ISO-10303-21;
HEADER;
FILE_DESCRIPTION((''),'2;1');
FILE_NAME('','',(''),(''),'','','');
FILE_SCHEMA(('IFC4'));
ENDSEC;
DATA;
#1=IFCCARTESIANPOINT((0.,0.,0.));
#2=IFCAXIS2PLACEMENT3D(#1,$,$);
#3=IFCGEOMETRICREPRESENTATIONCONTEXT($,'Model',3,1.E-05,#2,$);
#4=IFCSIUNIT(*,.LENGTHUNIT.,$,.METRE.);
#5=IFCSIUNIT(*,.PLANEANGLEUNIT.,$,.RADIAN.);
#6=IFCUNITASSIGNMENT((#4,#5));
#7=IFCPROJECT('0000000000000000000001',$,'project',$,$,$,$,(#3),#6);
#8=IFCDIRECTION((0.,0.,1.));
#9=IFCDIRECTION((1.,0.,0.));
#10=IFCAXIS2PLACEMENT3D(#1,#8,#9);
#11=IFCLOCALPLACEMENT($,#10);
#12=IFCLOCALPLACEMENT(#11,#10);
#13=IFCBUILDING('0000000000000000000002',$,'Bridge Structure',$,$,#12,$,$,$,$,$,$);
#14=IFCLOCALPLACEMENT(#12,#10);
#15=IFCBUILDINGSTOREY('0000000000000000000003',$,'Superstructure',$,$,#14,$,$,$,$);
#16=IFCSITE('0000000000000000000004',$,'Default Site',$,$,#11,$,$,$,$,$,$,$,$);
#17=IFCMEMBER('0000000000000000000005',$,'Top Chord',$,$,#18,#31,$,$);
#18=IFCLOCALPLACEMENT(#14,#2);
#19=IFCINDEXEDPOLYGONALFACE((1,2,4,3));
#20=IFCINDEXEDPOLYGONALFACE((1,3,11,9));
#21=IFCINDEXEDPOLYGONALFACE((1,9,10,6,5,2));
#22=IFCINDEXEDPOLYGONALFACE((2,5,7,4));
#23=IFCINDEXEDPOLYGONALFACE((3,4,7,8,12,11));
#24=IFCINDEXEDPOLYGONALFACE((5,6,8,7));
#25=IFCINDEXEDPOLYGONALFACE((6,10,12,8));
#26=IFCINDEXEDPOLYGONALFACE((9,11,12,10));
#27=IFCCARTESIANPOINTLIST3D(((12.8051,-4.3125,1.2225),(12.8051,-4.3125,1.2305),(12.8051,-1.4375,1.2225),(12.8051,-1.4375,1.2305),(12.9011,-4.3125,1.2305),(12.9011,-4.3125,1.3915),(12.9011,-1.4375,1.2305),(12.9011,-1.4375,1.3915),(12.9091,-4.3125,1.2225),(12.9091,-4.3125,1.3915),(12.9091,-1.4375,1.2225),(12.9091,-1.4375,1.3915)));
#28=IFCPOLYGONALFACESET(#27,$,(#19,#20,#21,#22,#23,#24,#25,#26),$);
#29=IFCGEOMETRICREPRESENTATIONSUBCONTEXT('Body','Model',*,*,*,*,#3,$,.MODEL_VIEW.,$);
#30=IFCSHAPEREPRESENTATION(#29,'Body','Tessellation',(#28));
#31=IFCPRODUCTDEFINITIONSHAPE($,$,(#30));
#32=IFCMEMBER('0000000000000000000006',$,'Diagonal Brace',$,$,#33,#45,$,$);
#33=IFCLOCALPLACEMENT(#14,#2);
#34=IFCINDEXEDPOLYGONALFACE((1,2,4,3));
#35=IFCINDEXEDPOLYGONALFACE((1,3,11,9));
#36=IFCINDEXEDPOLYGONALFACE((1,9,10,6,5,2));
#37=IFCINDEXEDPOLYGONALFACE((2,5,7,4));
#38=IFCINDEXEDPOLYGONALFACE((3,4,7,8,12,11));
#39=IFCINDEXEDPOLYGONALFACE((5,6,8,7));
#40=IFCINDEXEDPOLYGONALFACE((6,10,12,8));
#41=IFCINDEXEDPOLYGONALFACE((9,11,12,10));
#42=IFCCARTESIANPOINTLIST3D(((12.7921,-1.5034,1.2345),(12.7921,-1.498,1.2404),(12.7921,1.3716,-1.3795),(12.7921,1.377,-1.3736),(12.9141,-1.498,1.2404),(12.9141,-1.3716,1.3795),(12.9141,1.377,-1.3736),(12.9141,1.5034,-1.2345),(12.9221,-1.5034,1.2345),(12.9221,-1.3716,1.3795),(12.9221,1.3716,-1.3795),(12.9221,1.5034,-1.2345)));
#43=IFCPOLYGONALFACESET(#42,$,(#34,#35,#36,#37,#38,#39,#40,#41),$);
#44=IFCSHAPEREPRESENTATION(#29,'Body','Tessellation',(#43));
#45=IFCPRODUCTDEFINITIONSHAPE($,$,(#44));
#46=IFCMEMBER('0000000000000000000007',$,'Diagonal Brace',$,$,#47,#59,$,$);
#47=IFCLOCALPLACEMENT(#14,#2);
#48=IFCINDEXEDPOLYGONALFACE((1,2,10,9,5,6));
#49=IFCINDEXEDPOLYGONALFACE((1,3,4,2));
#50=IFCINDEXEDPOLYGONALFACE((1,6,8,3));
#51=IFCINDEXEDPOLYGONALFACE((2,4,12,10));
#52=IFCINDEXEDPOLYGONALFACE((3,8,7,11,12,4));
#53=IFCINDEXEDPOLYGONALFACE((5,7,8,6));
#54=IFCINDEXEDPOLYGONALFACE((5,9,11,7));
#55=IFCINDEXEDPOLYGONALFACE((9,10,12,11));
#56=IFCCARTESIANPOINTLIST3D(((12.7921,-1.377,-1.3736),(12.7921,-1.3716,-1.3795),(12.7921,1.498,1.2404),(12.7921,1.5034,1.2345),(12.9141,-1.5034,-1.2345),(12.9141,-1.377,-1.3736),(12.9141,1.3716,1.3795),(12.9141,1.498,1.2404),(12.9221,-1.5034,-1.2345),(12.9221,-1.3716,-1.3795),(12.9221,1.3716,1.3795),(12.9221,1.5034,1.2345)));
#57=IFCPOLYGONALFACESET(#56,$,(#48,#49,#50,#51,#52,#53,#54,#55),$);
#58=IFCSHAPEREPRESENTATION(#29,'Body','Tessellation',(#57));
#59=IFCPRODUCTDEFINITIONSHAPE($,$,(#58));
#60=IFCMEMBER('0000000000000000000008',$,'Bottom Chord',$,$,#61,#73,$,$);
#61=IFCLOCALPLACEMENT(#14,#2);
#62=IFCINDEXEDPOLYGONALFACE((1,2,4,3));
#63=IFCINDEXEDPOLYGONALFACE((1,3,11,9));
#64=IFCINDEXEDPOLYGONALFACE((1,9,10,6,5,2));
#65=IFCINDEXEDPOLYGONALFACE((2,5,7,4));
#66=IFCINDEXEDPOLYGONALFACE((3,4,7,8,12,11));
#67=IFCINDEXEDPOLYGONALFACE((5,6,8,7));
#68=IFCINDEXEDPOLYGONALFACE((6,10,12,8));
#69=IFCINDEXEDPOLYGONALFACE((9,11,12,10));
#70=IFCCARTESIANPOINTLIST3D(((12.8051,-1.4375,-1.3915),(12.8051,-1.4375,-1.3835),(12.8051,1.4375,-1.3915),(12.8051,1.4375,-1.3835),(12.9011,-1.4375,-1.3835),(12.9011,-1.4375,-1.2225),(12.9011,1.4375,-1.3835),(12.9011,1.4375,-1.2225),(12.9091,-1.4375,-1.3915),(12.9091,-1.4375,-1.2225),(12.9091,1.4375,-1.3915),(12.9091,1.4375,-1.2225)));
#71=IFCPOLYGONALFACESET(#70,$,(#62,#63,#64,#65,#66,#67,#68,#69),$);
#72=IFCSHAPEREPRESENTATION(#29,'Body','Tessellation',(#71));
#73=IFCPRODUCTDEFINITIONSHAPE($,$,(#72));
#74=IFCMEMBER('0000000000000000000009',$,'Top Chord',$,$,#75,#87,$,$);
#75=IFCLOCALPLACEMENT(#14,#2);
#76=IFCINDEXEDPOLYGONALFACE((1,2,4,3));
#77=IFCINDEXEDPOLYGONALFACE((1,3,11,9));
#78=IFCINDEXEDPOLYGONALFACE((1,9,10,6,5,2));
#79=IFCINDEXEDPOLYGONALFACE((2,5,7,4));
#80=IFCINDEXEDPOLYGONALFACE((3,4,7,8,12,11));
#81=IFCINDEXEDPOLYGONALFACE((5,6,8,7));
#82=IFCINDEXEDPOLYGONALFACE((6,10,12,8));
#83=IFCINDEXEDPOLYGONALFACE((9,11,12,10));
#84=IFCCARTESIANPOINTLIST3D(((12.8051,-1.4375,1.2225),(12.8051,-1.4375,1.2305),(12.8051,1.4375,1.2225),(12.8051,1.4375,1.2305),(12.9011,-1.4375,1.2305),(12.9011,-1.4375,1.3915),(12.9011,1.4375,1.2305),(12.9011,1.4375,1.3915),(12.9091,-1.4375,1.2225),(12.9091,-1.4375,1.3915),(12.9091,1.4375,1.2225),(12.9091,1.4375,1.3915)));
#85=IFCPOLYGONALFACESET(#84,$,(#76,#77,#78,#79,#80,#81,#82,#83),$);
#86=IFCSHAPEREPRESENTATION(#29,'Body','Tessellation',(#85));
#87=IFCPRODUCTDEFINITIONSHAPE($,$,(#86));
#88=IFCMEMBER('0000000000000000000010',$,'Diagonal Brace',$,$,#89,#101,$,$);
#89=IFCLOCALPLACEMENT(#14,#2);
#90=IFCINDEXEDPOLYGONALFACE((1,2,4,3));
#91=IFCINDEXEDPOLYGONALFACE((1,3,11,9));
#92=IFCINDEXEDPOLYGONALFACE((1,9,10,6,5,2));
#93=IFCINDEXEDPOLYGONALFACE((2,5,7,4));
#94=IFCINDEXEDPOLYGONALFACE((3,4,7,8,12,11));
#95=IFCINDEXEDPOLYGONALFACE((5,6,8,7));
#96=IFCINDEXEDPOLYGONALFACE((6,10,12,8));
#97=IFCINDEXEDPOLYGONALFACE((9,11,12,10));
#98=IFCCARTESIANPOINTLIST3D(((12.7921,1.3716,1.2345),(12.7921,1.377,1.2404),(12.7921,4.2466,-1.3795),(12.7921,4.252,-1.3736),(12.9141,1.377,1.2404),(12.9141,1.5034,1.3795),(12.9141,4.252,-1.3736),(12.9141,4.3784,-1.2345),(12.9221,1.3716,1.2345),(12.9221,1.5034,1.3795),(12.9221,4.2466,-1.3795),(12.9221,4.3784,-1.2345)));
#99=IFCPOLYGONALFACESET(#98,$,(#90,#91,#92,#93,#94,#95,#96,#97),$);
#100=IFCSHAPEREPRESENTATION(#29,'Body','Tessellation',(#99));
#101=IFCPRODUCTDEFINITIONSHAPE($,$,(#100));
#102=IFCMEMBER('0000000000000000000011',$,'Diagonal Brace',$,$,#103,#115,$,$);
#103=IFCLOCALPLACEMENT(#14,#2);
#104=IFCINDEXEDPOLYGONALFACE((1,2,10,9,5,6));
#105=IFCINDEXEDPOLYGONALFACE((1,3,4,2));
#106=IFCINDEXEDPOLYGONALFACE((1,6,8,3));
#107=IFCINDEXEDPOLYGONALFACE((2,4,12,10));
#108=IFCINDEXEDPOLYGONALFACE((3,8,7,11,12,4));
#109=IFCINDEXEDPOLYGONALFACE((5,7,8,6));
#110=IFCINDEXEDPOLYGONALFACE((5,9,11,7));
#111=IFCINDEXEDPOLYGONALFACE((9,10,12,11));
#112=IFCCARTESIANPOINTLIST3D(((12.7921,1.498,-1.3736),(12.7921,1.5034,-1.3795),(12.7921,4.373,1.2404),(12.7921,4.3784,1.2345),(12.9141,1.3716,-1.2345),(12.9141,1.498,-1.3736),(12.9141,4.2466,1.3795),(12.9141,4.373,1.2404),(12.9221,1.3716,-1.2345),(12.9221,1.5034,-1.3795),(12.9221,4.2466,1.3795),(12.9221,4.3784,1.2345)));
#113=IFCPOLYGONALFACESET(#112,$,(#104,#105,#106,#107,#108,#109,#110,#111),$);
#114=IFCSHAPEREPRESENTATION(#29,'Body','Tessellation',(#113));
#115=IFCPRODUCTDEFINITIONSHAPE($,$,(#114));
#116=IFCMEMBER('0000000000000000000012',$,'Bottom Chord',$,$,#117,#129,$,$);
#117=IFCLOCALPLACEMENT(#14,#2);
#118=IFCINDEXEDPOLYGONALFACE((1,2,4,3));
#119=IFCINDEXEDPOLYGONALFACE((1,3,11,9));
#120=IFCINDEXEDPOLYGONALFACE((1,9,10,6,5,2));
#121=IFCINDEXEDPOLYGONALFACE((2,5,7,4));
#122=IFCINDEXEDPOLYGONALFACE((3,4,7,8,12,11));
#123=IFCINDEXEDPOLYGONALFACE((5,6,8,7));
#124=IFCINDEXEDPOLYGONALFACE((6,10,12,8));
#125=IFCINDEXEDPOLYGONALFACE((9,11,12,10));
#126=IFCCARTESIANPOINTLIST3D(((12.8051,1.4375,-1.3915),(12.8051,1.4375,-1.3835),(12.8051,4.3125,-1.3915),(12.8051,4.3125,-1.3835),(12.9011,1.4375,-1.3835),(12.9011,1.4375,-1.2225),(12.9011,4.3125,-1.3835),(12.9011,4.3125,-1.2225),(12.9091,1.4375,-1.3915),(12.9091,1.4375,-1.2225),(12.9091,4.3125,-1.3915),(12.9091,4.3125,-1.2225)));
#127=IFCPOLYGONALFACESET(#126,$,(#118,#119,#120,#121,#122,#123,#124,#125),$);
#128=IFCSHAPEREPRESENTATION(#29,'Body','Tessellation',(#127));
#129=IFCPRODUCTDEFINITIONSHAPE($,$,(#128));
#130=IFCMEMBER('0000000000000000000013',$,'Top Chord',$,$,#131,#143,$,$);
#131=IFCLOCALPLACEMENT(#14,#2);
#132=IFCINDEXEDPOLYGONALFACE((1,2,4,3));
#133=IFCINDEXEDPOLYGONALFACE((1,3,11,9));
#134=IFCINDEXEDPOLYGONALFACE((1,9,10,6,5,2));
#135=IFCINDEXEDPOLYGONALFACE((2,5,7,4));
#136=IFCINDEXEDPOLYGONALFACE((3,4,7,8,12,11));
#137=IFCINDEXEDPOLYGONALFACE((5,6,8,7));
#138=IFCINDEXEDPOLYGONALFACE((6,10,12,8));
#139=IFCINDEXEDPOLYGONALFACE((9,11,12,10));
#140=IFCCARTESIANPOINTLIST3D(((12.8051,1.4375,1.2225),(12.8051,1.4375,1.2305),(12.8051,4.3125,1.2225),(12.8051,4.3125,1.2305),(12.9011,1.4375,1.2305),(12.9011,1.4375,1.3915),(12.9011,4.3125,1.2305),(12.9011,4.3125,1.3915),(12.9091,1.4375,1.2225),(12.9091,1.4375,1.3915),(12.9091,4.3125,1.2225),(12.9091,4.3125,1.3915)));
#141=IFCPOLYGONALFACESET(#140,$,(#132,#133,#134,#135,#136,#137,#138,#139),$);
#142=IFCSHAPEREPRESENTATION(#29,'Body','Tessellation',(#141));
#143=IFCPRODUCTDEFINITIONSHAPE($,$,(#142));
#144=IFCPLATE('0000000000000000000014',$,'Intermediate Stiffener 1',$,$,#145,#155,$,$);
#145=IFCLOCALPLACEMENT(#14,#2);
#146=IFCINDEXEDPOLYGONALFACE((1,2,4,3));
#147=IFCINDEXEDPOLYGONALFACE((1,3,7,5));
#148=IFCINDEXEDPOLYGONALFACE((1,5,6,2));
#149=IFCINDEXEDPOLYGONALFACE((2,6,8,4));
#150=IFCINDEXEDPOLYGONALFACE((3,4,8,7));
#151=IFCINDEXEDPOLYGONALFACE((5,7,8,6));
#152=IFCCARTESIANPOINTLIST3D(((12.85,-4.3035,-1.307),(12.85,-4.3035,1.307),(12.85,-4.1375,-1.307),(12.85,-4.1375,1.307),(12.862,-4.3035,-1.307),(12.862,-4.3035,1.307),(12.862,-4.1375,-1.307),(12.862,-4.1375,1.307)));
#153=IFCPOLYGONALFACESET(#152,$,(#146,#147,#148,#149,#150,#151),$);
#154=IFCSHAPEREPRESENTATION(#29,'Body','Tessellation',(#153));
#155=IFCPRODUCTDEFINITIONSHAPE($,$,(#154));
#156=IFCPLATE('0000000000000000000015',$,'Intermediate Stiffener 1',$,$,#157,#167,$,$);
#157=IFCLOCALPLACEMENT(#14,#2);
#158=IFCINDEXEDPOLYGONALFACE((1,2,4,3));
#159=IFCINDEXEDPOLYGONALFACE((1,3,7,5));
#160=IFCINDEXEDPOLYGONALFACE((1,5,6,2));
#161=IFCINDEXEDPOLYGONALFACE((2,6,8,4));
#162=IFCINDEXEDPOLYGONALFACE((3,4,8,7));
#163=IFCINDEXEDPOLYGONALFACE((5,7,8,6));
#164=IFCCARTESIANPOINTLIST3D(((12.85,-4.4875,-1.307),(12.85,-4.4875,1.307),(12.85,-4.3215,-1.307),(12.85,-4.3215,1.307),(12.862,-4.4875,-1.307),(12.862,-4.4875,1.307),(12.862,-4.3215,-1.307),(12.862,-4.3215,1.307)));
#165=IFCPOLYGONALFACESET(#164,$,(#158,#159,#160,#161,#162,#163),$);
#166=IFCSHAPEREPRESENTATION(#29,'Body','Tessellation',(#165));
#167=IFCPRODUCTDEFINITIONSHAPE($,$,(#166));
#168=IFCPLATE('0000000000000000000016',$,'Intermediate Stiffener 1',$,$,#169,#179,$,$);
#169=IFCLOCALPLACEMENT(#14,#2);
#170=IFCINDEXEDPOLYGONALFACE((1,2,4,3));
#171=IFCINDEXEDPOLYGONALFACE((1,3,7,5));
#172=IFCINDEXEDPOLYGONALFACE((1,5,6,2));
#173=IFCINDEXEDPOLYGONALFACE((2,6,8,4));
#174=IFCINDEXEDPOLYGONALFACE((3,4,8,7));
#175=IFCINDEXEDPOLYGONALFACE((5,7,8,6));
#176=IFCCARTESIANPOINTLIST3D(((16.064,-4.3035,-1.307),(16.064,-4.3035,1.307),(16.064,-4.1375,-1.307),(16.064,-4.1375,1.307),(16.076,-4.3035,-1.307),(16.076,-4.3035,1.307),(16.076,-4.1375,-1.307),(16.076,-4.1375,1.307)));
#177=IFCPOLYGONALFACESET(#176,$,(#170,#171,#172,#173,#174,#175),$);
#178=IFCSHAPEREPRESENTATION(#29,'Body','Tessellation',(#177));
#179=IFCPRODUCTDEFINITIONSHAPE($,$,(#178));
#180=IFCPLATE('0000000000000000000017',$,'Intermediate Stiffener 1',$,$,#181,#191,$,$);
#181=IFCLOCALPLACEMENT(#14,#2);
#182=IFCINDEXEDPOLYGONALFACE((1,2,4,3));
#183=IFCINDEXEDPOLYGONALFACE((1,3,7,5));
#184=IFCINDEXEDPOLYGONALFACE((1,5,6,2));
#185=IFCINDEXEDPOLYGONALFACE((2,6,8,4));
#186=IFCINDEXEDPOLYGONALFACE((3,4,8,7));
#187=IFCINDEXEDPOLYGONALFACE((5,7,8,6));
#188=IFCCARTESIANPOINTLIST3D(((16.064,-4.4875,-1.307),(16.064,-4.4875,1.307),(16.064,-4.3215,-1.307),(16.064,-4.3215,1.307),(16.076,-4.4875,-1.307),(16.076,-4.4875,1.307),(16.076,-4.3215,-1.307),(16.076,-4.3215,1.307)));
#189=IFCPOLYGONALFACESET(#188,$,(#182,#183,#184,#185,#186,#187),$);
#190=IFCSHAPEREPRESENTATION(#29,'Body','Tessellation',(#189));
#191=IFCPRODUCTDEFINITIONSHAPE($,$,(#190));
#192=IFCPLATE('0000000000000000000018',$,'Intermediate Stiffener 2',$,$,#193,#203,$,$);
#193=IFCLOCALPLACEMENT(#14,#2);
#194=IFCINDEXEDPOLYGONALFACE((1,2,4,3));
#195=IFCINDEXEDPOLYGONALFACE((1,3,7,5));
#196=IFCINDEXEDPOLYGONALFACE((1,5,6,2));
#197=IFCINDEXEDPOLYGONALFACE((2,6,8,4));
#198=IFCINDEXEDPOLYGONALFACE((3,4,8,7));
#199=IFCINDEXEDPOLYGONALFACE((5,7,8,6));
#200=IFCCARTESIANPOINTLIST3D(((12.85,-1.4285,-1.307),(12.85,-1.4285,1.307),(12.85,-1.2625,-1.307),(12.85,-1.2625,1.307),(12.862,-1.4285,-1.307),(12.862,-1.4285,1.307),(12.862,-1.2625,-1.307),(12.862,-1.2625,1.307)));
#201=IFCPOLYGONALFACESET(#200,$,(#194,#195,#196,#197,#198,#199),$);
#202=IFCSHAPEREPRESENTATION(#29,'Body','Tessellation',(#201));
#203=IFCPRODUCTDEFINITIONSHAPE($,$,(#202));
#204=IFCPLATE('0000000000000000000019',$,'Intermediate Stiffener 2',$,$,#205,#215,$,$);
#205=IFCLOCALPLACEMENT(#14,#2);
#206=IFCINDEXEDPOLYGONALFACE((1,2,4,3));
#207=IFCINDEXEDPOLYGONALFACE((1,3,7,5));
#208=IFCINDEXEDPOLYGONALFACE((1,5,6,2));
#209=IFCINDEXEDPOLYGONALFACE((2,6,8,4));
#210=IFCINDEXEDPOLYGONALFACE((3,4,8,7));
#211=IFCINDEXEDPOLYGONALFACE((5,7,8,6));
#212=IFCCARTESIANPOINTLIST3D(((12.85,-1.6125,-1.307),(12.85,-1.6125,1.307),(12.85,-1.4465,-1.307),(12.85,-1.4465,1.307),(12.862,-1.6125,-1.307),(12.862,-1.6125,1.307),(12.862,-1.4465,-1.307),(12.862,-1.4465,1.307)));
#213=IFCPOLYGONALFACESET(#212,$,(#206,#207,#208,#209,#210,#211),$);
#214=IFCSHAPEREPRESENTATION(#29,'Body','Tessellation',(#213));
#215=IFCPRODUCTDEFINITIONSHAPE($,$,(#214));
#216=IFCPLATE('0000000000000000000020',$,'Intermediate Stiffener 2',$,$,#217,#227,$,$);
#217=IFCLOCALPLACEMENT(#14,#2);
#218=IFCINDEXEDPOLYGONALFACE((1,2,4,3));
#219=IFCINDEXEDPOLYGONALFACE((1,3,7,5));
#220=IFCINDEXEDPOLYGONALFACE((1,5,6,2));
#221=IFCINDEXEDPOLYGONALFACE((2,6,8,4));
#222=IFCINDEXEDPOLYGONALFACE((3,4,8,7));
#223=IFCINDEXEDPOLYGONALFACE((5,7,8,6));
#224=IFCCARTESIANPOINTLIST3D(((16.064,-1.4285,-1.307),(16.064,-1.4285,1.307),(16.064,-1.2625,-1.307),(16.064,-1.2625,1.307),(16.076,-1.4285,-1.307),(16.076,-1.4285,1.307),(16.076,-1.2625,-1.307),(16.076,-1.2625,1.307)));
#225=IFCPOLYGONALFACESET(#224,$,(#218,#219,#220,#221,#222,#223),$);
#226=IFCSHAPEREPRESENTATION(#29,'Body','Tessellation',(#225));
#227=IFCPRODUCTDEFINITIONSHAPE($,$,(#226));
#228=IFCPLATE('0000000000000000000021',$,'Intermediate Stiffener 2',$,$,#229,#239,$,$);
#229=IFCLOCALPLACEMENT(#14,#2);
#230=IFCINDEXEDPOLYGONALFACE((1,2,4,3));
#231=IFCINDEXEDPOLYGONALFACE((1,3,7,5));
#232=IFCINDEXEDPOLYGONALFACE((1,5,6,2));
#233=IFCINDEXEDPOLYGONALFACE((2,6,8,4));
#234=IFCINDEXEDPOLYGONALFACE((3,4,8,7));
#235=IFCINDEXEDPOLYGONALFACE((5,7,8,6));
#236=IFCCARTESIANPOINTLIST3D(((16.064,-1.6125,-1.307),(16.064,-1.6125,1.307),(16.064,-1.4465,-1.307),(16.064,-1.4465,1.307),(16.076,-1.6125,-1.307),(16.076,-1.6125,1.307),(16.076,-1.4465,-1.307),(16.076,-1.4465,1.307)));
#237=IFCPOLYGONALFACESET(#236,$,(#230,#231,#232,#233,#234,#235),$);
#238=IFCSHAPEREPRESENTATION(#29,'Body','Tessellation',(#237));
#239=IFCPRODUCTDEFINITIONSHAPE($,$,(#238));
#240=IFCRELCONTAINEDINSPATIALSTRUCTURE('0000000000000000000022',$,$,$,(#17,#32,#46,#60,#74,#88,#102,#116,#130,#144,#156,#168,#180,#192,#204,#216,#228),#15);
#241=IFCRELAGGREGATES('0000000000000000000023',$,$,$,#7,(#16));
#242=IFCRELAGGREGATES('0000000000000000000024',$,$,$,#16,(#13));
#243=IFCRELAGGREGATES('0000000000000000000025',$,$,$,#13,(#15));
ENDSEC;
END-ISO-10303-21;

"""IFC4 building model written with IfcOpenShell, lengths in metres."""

from ifc_helpers import new_model, si_unit, frame, origin, origin_with_axes, origin_2d_with_axis, place, context, subcontext, project, spatial, rectangle, l_section, extrude, element, save


model = new_model("IFC4")

# Units and contexts
model_context = context("Model", 3, precision=1e-05, world=origin())
body_context = subcontext(model_context, "Body", "Model", "MODEL_VIEW")
ifc_project = project(units=[si_unit("LENGTHUNIT", "METRE"), si_unit("PLANEANGLEUNIT", "RADIAN")], contexts=[model_context])

# Site, building, storey
site_placement = place(None, origin_with_axes())
site = spatial("IfcSite", under=ifc_project, at=site_placement, Name="Default Site")
building_placement = place(site_placement, origin_with_axes())
building = spatial("IfcBuilding", under=site, at=building_placement, Name="Bridge Structure")
storey_placement = place(building_placement, origin_with_axes())
storey = spatial("IfcBuildingStorey", under=building, at=storey_placement, Name="Superstructure")

# Members
for number, where, z_axis, x_axis, name in (
    (1, (12.8571, -4.3125, 1.307), (0.0, 1.0, 0.0), (-1.0, 0.0, 0.0), "Top Chord"),
):
    element("IfcMember", number, at=place(storey_placement, frame(where, z_axis=z_axis, x_axis=x_axis)), inside=storey, Name=name, context=body_context, shape_type="SweptSolid", body=[
        extrude(l_section(Depth=0.169, Width=0.104, Thickness=0.008, at=origin_2d_with_axis()), origin_with_axes(), (0.0, 0.0, 1.0), 2.875),
    ])
for number, where, z_axis, x_axis, name in (
    (2, (12.8571, -1.4375, 1.307), (0.0, 0.739893, -0.672724), (-1.0, 0.0, 0.0), "Diagonal Brace"),
    (3, (12.8571, -1.4375, -1.307), (0.0, 0.739893, 0.672724), (-1.0, 0.0, 0.0), "Diagonal Brace"),
):
    element("IfcMember", number, at=place(storey_placement, frame(where, z_axis=z_axis, x_axis=x_axis)), inside=storey, Name=name, context=body_context, shape_type="SweptSolid", body=[
        extrude(l_section(Depth=0.196, Width=0.13, Thickness=0.008, at=origin_2d_with_axis()), origin_with_axes(), (0.0, 0.0, 1.0), 3.8857),
    ])
for number, where, z_axis, x_axis, name in (
    (4, (12.8571, -1.4375, -1.307), (0.0, 1.0, 0.0), (-1.0, 0.0, 0.0), "Bottom Chord"),
    (5, (12.8571, -1.4375, 1.307), (0.0, 1.0, 0.0), (-1.0, 0.0, 0.0), "Top Chord"),
):
    element("IfcMember", number, at=place(storey_placement, frame(where, z_axis=z_axis, x_axis=x_axis)), inside=storey, Name=name, context=body_context, shape_type="SweptSolid", body=[
        extrude(l_section(Depth=0.169, Width=0.104, Thickness=0.008, at=origin_2d_with_axis()), origin_with_axes(), (0.0, 0.0, 1.0), 2.875),
    ])
for number, where, z_axis, x_axis, name in (
    (6, (12.8571, 1.4375, 1.307), (0.0, 0.739893, -0.672724), (-1.0, 0.0, 0.0), "Diagonal Brace"),
    (7, (12.8571, 1.4375, -1.307), (0.0, 0.739893, 0.672724), (-1.0, 0.0, 0.0), "Diagonal Brace"),
):
    element("IfcMember", number, at=place(storey_placement, frame(where, z_axis=z_axis, x_axis=x_axis)), inside=storey, Name=name, context=body_context, shape_type="SweptSolid", body=[
        extrude(l_section(Depth=0.196, Width=0.13, Thickness=0.008, at=origin_2d_with_axis()), origin_with_axes(), (0.0, 0.0, 1.0), 3.8857),
    ])
for number, where, z_axis, x_axis, name in (
    (8, (12.8571, 1.4375, -1.307), (0.0, 1.0, 0.0), (-1.0, 0.0, 0.0), "Bottom Chord"),
    (9, (12.8571, 1.4375, 1.307), (0.0, 1.0, 0.0), (-1.0, 0.0, 0.0), "Top Chord"),
):
    element("IfcMember", number, at=place(storey_placement, frame(where, z_axis=z_axis, x_axis=x_axis)), inside=storey, Name=name, context=body_context, shape_type="SweptSolid", body=[
        extrude(l_section(Depth=0.169, Width=0.104, Thickness=0.008, at=origin_2d_with_axis()), origin_with_axes(), (0.0, 0.0, 1.0), 2.875),
    ])

# Plates
for number, where, z_axis, x_axis, name in (
    (10, (12.856, -4.2205, -1.307), (0.0, 0.0, 1.0), (1.0, 0.0, 0.0), "Intermediate Stiffener 1"),
    (11, (12.856, -4.4045, -1.307), (0.0, 0.0, 1.0), (1.0, 0.0, 0.0), "Intermediate Stiffener 1"),
    (12, (16.07, -4.2205, -1.307), (0.0, 0.0, 1.0), (1.0, 0.0, 0.0), "Intermediate Stiffener 1"),
    (13, (16.07, -4.4045, -1.307), (0.0, 0.0, 1.0), (1.0, 0.0, 0.0), "Intermediate Stiffener 1"),
    (14, (12.856, -1.3455, -1.307), (0.0, 0.0, 1.0), (1.0, 0.0, 0.0), "Intermediate Stiffener 2"),
    (15, (12.856, -1.5295, -1.307), (0.0, 0.0, 1.0), (1.0, 0.0, 0.0), "Intermediate Stiffener 2"),
    (16, (16.07, -1.3455, -1.307), (0.0, 0.0, 1.0), (1.0, 0.0, 0.0), "Intermediate Stiffener 2"),
    (17, (16.07, -1.5295, -1.307), (0.0, 0.0, 1.0), (1.0, 0.0, 0.0), "Intermediate Stiffener 2"),
):
    element("IfcPlate", number, at=place(storey_placement, frame(where, z_axis=z_axis, x_axis=x_axis)), inside=storey, Name=name, context=body_context, shape_type="SweptSolid", body=[
        extrude(rectangle(XDim=0.012, YDim=0.166, at=origin_2d_with_axis()), origin_with_axes(), (0.0, 0.0, 1.0), 2.614),
    ])

save(model, "model.ifc")
